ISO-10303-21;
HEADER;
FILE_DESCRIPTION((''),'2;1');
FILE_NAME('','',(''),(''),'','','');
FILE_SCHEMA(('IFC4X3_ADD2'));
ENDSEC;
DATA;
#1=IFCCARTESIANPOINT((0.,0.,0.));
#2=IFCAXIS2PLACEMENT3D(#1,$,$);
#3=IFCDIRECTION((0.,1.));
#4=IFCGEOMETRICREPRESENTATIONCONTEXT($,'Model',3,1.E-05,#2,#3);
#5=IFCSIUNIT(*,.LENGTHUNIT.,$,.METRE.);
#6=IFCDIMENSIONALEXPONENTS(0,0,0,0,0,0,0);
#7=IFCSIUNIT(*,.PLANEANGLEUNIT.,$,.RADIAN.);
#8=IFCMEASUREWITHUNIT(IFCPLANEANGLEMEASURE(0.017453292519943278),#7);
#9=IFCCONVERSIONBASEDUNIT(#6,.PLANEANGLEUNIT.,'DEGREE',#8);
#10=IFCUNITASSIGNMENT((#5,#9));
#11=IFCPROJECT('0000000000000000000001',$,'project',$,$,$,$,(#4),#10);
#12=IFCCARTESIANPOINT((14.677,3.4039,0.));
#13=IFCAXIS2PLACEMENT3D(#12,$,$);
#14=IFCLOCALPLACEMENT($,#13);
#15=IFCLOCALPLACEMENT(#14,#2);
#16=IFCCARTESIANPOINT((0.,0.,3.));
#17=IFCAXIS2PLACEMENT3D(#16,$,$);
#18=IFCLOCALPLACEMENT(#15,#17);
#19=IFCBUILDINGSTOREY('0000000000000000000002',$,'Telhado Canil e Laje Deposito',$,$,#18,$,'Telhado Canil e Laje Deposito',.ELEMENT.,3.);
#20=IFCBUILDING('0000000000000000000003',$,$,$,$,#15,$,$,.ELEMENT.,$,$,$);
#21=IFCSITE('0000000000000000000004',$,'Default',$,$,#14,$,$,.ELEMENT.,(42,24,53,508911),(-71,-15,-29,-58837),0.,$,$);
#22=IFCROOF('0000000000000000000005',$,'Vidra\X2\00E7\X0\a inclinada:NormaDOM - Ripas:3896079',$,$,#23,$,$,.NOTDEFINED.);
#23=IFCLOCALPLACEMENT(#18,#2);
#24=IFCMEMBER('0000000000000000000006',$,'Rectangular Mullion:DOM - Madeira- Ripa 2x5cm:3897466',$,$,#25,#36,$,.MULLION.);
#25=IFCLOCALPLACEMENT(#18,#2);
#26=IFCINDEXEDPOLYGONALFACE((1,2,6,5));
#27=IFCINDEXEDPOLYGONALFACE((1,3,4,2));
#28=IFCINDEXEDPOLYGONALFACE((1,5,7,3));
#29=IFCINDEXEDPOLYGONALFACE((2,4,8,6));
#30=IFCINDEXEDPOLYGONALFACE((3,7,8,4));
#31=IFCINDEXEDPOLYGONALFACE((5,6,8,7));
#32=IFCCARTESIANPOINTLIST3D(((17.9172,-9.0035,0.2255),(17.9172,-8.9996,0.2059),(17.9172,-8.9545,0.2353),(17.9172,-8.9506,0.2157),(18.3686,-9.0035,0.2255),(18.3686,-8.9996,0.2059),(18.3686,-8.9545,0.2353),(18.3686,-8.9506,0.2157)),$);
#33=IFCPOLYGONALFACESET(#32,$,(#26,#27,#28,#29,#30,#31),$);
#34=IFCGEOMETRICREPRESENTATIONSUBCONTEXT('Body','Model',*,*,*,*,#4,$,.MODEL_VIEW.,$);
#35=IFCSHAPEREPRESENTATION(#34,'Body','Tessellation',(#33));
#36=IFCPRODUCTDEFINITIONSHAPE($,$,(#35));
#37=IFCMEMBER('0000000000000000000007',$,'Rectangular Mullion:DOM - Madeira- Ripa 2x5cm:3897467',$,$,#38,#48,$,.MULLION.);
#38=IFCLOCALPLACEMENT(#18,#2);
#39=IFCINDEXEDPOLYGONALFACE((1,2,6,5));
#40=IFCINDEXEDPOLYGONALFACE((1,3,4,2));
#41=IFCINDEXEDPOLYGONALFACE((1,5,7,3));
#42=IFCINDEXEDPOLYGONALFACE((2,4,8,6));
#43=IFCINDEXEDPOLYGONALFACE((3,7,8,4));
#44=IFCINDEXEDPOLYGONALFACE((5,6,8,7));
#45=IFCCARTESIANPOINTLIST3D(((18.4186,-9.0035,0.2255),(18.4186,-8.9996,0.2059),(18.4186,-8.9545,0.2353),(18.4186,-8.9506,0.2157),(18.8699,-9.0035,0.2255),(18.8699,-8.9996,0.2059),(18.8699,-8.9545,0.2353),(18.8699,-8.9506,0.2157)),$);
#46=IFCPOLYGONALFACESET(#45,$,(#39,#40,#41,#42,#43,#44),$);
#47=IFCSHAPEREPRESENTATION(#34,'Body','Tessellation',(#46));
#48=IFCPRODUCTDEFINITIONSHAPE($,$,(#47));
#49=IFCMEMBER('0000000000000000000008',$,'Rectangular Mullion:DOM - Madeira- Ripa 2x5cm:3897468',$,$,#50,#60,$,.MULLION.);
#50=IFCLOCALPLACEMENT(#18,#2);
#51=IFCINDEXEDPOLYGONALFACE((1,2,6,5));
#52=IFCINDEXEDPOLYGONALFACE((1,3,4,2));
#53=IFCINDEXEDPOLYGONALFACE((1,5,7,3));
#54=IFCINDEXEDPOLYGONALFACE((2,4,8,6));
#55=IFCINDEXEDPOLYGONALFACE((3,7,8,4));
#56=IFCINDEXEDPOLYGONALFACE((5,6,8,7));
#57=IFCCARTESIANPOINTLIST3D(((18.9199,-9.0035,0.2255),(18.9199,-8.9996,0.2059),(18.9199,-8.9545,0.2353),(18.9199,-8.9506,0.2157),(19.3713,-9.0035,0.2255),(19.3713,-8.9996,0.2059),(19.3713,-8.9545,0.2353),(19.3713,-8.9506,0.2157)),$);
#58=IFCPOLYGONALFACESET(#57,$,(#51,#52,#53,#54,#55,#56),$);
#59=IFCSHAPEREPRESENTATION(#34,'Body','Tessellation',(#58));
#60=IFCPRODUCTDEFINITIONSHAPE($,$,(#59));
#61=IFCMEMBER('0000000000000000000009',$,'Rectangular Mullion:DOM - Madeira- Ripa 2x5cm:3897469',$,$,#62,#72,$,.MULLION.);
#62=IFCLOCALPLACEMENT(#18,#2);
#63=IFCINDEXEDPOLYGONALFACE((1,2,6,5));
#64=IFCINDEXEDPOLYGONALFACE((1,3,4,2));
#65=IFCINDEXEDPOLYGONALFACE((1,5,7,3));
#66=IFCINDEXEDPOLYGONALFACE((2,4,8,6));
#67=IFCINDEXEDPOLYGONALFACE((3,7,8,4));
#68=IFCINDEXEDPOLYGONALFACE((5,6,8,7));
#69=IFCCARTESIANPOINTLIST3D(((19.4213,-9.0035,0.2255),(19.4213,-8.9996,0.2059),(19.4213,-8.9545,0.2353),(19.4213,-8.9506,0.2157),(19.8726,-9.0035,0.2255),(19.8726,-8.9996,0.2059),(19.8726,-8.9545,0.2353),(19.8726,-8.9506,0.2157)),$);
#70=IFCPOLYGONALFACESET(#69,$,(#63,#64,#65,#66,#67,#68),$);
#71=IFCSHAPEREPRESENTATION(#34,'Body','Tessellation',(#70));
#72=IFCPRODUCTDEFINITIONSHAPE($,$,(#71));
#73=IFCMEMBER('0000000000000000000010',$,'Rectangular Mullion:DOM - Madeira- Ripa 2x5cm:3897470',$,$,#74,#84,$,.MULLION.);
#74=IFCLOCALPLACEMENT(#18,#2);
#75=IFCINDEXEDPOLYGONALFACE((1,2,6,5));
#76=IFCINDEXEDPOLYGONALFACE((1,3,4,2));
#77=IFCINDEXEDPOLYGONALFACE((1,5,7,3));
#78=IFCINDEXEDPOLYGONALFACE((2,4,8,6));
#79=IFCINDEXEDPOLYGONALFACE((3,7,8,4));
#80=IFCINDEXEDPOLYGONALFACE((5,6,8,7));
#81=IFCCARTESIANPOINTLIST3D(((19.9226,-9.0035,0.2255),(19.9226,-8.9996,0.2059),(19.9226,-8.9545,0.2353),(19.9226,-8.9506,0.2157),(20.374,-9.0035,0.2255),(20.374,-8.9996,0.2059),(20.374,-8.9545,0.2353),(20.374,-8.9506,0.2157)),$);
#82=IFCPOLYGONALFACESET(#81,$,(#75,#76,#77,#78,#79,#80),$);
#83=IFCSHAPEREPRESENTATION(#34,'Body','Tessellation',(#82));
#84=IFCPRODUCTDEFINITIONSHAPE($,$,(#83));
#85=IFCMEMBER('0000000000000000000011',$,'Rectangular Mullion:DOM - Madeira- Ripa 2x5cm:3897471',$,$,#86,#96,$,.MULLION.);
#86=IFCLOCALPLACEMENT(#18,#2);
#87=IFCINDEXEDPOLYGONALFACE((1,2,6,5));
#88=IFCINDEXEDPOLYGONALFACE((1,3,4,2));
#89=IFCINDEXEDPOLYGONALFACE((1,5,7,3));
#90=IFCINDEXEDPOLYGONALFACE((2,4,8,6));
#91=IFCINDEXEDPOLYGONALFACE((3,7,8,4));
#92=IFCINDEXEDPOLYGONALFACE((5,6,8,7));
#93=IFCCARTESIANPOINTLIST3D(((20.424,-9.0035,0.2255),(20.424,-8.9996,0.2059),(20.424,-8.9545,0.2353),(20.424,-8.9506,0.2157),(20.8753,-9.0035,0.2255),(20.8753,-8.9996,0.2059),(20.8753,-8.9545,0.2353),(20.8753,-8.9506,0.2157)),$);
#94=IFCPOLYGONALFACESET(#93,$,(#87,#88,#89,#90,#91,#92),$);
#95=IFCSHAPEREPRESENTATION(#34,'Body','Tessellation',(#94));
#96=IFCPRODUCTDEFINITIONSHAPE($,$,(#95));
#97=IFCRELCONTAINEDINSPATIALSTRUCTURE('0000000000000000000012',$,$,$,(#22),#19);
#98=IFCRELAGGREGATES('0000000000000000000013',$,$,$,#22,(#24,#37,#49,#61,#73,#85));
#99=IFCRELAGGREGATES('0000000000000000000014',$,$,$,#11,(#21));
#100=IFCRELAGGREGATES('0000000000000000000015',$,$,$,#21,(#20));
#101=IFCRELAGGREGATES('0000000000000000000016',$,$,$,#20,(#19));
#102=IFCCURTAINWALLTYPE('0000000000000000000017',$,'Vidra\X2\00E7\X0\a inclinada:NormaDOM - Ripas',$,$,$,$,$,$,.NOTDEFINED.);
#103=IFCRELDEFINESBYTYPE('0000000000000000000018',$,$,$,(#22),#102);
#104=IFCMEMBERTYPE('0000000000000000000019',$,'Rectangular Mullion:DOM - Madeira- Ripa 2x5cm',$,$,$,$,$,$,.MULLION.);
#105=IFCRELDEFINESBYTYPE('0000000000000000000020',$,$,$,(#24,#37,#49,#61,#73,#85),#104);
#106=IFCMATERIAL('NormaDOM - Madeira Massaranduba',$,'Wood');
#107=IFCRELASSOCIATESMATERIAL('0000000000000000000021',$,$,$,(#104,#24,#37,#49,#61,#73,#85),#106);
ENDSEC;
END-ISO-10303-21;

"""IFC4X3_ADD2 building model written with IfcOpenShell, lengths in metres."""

from ifc_helpers import new_model, entity, si_unit, converted_unit, direction, frame, origin, origin_2d_with_axis, place, context, subcontext, project, spatial, rectangle, extrude, source, transform, mapped, material, material_profile, profile_set, profile_usage, type_object, type_shapes, element, aggregate, save


model = new_model("IFC4X3_ADD2")

# Units and contexts
model_context = context("Model", 3, precision=1e-05, world=origin(), true_north=direction((0.0, 1.0)))
body_context = subcontext(model_context, "Body", "Model", "MODEL_VIEW")
ifc_project = project(units=[si_unit("LENGTHUNIT", "METRE"), converted_unit("PLANEANGLEUNIT", "DEGREE", entity("IfcPlaneAngleMeasure", 0.017453292519943278), si_unit("PLANEANGLEUNIT", "RADIAN"), dimensions=[0, 0, 0, 0, 0, 0, 0])], contexts=[model_context])

# Site, building, storey
site_placement = place(None, frame((14.677, 3.4039, 0.0)))
site = spatial("IfcSite", under=ifc_project, at=site_placement, Name="Default", CompositionType="ELEMENT", RefLatitude=(42, 24, 53, 508911), RefLongitude=(-71, -15, -29, -58837), RefElevation=0.0)
building_placement = place(site_placement, origin())
building = spatial("IfcBuilding", under=site, at=building_placement, CompositionType="ELEMENT")
storey_placement = place(building_placement, frame((0.0, 0.0, 3.0)))
storey = spatial("IfcBuildingStorey", under=building, at=storey_placement, Name="Telhado Canil e Laje Deposito", LongName="Telhado Canil e Laje Deposito", CompositionType="ELEMENT", Elevation=3.0)

# Roof
ifc_material = material(Name="NormaDOM - Madeira Massaranduba", Category="Wood")
ifc_material_profile_1 = material_profile(ifc_material, rectangle(XDim=0.05, YDim=0.02, at=origin_2d_with_axis()), Name="DOM - Madeira- Ripa 2x5cm")
ifc_profile_set_1 = profile_set([ifc_material_profile_1], Name="DOM - Madeira- Ripa 2x5cm")
ifc_profile_usage_1 = profile_usage(ifc_profile_set_1)
curtain_wall_type_1 = type_object("IfcCurtainWallType", Name="Vidraça inclinada:NormaDOM - Ripas", PredefinedType="NOTDEFINED")
roof_1_placement = place(storey_placement, frame((0.0, 0.0, -3.0)))
roof_1 = element("IfcRoof", 1, at=roof_1_placement, inside=storey, type_object=curtain_wall_type_1, Name="Vidraça inclinada:NormaDOM - Ripas:3896079", PredefinedType="NOTDEFINED")

# Members
member_type_1 = type_object("IfcMemberType", Name="Rectangular Mullion:DOM - Madeira- Ripa 2x5cm", PredefinedType="MULLION", material=ifc_profile_set_1)
shared_shape_1 = source(origin(), body_context, "Body", "SweptSolid", [
    extrude(rectangle(XDim=0.05, YDim=0.02, at=origin_2d_with_axis()), frame((0.025, 0.01, -0.4514), z_axis=(0.0, 0.0, 1.0), x_axis=(-1.0, 0.0, 0.0)), (0.0, 0.0, 1.0), 0.4514),
])
type_shapes(member_type_1, [shared_shape_1])
member_1_placement = place(roof_1_placement, frame((17.9172, -9.0035, 3.2255), z_axis=(-1.0, 0.0, 0.0), x_axis=(0.0, 0.980581, 0.196116)))
member_1 = element("IfcMember", 2, at=member_1_placement, type_object=member_type_1, material=ifc_profile_usage_1, Name="Rectangular Mullion:DOM - Madeira- Ripa 2x5cm:3897466", PredefinedType="MULLION", context=body_context, shape_type="MappedRepresentation", body=[
    mapped(shared_shape_1, transform((0.0, 0.0, 0.0), scale=1.0)),
])
member_2_placement = place(roof_1_placement, frame((18.4186, -9.0035, 3.2255), z_axis=(-1.0, 0.0, 0.0), x_axis=(0.0, 0.980581, 0.196116)))
member_2 = element("IfcMember", 3, at=member_2_placement, type_object=member_type_1, material=ifc_profile_usage_1, Name="Rectangular Mullion:DOM - Madeira- Ripa 2x5cm:3897467", PredefinedType="MULLION", context=body_context, shape_type="MappedRepresentation", body=[
    mapped(shared_shape_1, transform((0.0, 0.0, 0.0), scale=1.0)),
])
member_3_placement = place(roof_1_placement, frame((18.9199, -9.0035, 3.2255), z_axis=(-1.0, 0.0, 0.0), x_axis=(0.0, 0.980581, 0.196116)))
member_3 = element("IfcMember", 4, at=member_3_placement, type_object=member_type_1, material=ifc_profile_usage_1, Name="Rectangular Mullion:DOM - Madeira- Ripa 2x5cm:3897468", PredefinedType="MULLION", context=body_context, shape_type="MappedRepresentation", body=[
    mapped(shared_shape_1, transform((0.0, 0.0, 0.0), scale=1.0)),
])
member_4_placement = place(roof_1_placement, frame((19.4213, -9.0035, 3.2255), z_axis=(-1.0, 0.0, 0.0), x_axis=(0.0, 0.980581, 0.196116)))
member_4 = element("IfcMember", 5, at=member_4_placement, type_object=member_type_1, material=ifc_profile_usage_1, Name="Rectangular Mullion:DOM - Madeira- Ripa 2x5cm:3897469", PredefinedType="MULLION", context=body_context, shape_type="MappedRepresentation", body=[
    mapped(shared_shape_1, transform((0.0, 0.0, 0.0), scale=1.0)),
])
member_5_placement = place(roof_1_placement, frame((19.9226, -9.0035, 3.2255), z_axis=(-1.0, 0.0, 0.0), x_axis=(0.0, 0.980581, 0.196116)))
member_5 = element("IfcMember", 6, at=member_5_placement, type_object=member_type_1, material=ifc_profile_usage_1, Name="Rectangular Mullion:DOM - Madeira- Ripa 2x5cm:3897470", PredefinedType="MULLION", context=body_context, shape_type="MappedRepresentation", body=[
    mapped(shared_shape_1, transform((0.0, 0.0, 0.0), scale=1.0)),
])
member_6_placement = place(roof_1_placement, frame((20.424, -9.0035, 3.2255), z_axis=(-1.0, 0.0, 0.0), x_axis=(0.0, 0.980581, 0.196116)))
member_6 = element("IfcMember", 7, at=member_6_placement, type_object=member_type_1, material=ifc_profile_usage_1, Name="Rectangular Mullion:DOM - Madeira- Ripa 2x5cm:3897471", PredefinedType="MULLION", context=body_context, shape_type="MappedRepresentation", body=[
    mapped(shared_shape_1, transform((0.0, 0.0, 0.0), scale=1.0)),
])
aggregate(roof_1, [member_1, member_2, member_3, member_4, member_5, member_6])

save(model, "model.ifc")
